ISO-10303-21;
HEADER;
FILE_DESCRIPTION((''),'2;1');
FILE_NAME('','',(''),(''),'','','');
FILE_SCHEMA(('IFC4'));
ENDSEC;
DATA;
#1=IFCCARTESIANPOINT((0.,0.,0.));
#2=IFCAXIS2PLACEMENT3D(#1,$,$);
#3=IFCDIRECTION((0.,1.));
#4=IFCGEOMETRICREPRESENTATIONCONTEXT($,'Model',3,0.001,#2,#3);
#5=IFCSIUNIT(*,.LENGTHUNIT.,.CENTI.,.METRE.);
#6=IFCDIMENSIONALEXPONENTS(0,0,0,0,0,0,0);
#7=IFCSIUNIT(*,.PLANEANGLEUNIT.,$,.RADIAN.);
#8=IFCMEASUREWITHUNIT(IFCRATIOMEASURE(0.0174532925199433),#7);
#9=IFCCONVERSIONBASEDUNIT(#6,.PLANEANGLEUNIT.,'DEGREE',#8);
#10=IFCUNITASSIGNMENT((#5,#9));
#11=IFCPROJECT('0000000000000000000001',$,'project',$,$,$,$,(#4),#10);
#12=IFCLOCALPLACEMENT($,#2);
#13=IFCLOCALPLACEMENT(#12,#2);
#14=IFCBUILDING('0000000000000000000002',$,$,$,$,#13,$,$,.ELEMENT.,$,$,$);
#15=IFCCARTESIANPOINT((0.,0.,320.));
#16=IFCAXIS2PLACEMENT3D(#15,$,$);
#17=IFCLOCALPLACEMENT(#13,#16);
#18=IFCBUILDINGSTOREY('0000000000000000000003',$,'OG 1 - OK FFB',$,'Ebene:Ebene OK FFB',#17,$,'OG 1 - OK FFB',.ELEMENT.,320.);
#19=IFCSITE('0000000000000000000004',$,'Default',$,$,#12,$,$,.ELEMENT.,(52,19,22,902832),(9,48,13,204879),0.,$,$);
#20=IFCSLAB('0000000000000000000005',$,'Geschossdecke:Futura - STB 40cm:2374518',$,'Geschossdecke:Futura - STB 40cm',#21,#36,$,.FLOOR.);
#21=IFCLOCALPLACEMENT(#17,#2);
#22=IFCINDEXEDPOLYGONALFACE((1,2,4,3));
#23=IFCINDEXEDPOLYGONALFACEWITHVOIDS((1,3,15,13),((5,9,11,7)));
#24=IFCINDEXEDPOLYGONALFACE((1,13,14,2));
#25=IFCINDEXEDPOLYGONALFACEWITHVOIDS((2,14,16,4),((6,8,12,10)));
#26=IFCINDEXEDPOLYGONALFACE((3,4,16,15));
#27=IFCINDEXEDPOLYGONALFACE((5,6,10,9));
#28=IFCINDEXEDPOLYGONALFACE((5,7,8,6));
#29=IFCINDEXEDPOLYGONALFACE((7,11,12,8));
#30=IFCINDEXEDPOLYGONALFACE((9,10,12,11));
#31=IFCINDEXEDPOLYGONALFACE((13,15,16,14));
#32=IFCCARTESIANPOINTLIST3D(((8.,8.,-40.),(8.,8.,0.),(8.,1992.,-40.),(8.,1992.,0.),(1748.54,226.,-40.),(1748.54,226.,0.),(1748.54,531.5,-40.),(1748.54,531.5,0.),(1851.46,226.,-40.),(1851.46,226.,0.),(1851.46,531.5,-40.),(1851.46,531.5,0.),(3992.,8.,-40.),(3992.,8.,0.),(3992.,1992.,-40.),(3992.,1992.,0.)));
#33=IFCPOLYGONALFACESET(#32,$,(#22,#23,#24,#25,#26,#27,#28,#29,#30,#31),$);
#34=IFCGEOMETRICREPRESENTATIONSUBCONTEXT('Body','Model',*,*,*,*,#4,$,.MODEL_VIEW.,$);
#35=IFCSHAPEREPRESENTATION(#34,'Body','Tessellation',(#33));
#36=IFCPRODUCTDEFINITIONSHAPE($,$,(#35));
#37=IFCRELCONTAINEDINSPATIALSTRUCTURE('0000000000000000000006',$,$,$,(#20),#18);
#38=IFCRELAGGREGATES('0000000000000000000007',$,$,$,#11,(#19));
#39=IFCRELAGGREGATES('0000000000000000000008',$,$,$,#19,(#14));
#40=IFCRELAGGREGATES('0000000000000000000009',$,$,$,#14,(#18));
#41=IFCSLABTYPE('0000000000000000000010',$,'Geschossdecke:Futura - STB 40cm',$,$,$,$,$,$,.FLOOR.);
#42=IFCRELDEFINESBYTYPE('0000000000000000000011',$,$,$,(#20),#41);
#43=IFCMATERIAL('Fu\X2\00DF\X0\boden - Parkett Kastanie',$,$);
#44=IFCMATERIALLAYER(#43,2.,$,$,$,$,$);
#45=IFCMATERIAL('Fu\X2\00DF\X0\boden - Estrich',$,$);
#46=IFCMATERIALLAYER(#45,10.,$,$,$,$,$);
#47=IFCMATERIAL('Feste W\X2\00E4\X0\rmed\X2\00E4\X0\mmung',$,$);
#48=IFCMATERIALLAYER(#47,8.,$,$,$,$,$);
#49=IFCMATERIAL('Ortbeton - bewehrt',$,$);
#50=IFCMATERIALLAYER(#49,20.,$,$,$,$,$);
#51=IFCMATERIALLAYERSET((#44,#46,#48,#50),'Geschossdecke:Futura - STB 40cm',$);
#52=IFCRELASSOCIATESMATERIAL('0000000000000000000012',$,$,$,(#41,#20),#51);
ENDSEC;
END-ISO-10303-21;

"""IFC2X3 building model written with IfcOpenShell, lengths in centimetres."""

from ifc_helpers import new_model, entity, si_unit, converted_unit, direction, frame, frame_2d, origin, place, context, subcontext, project, spatial, rectangle, extrude, material, layer, layer_set, layer_usage, type_object, element, save


model = new_model("IFC2X3")

# Units and contexts
model_context = context("Model", 3, precision=0.001, world=origin(), true_north=direction((0.0, 1.0)))
body_context = subcontext(model_context, "Body", "Model", "MODEL_VIEW")
ifc_project = project(units=[si_unit("LENGTHUNIT", "METRE", prefix="CENTI"), converted_unit("PLANEANGLEUNIT", "DEGREE", entity("IfcRatioMeasure", 0.0174532925199433), si_unit("PLANEANGLEUNIT", "RADIAN"), dimensions=[0, 0, 0, 0, 0, 0, 0])], contexts=[model_context])

# Site, building, storey
site_placement = place(None, frame((0.0, 0.0, 0.0)))
site = spatial("IfcSite", under=ifc_project, at=site_placement, Name="Default", CompositionType="ELEMENT", RefLatitude=(52, 19, 22, 902832), RefLongitude=(9, 48, 13, 204879), RefElevation=0.0)
building_placement = place(site_placement, origin())
building = spatial("IfcBuilding", under=site, at=building_placement, CompositionType="ELEMENT")
storey_placement = place(building_placement, frame((0.0, 0.0, 320.0)))
storey = spatial("IfcBuildingStorey", under=building, at=storey_placement, Name="OG 1 - OK FFB", ObjectType="Ebene:Ebene OK FFB", LongName="OG 1 - OK FFB", CompositionType="ELEMENT", Elevation=320.0)

# Slab, opening
ifc_material_1 = material(Name="Fußboden - Parkett Kastanie")
ifc_layer_1 = layer(ifc_material_1, 2.0)
ifc_material_2 = material(Name="Fußboden - Estrich")
ifc_layer_2 = layer(ifc_material_2, 10.0)
ifc_material_3 = material(Name="Feste Wärmedämmung")
ifc_layer_3 = layer(ifc_material_3, 8.0)
ifc_material_4 = material(Name="Ortbeton - bewehrt")
ifc_layer_4 = layer(ifc_material_4, 20.0)
ifc_layer_set = layer_set([ifc_layer_1, ifc_layer_2, ifc_layer_3, ifc_layer_4], Name="Geschossdecke:Futura - STB 40cm")
ifc_layer_usage = layer_usage(ifc_layer_set, "AXIS3", "POSITIVE", 0.0)
slab_type = type_object("IfcSlabType", Name="Geschossdecke:Futura - STB 40cm", PredefinedType="FLOOR", material=ifc_layer_set)
slab_placement = place(storey_placement, frame((8.0, 8.0, -40.0)))
slab = element("IfcSlab", 1, at=slab_placement, inside=storey, type_object=slab_type, material=ifc_layer_usage, Name="Geschossdecke:Futura - STB 40cm:2374518", ObjectType="Geschossdecke:Futura - STB 40cm", PredefinedType="FLOOR", context=body_context, shape_type="SweptSolid", body=[
    extrude(rectangle(XDim=1984.0, YDim=3984.0, at=frame_2d((0.0, 0.0), x_axis=(0.0, -1.0))), frame((1992.0, 992.0, 40.0), z_axis=(0.0, 0.0, -1.0), x_axis=(-1.0, 0.0, 0.0)), (0.0, 0.0, 1.0), 40.0),
])
opening_placement = place(storey_placement, frame((8.0, 8.0, -40.0)))
element("IfcOpeningElement", 2, at=opening_placement, cuts=slab, ObjectType="Opening", context=body_context, shape_type="SweptSolid", body=[
    extrude(rectangle(XDim=305.5, YDim=102.92, at=frame_2d((200.0, -621.25), x_axis=(0.0, 1.0))), frame((1992.0, 992.0, 40.0), z_axis=(0.0, 0.0, -1.0), x_axis=(-1.0, 0.0, 0.0)), (0.0, 0.0, 1.0), 40.0),
])

save(model, "model.ifc")
